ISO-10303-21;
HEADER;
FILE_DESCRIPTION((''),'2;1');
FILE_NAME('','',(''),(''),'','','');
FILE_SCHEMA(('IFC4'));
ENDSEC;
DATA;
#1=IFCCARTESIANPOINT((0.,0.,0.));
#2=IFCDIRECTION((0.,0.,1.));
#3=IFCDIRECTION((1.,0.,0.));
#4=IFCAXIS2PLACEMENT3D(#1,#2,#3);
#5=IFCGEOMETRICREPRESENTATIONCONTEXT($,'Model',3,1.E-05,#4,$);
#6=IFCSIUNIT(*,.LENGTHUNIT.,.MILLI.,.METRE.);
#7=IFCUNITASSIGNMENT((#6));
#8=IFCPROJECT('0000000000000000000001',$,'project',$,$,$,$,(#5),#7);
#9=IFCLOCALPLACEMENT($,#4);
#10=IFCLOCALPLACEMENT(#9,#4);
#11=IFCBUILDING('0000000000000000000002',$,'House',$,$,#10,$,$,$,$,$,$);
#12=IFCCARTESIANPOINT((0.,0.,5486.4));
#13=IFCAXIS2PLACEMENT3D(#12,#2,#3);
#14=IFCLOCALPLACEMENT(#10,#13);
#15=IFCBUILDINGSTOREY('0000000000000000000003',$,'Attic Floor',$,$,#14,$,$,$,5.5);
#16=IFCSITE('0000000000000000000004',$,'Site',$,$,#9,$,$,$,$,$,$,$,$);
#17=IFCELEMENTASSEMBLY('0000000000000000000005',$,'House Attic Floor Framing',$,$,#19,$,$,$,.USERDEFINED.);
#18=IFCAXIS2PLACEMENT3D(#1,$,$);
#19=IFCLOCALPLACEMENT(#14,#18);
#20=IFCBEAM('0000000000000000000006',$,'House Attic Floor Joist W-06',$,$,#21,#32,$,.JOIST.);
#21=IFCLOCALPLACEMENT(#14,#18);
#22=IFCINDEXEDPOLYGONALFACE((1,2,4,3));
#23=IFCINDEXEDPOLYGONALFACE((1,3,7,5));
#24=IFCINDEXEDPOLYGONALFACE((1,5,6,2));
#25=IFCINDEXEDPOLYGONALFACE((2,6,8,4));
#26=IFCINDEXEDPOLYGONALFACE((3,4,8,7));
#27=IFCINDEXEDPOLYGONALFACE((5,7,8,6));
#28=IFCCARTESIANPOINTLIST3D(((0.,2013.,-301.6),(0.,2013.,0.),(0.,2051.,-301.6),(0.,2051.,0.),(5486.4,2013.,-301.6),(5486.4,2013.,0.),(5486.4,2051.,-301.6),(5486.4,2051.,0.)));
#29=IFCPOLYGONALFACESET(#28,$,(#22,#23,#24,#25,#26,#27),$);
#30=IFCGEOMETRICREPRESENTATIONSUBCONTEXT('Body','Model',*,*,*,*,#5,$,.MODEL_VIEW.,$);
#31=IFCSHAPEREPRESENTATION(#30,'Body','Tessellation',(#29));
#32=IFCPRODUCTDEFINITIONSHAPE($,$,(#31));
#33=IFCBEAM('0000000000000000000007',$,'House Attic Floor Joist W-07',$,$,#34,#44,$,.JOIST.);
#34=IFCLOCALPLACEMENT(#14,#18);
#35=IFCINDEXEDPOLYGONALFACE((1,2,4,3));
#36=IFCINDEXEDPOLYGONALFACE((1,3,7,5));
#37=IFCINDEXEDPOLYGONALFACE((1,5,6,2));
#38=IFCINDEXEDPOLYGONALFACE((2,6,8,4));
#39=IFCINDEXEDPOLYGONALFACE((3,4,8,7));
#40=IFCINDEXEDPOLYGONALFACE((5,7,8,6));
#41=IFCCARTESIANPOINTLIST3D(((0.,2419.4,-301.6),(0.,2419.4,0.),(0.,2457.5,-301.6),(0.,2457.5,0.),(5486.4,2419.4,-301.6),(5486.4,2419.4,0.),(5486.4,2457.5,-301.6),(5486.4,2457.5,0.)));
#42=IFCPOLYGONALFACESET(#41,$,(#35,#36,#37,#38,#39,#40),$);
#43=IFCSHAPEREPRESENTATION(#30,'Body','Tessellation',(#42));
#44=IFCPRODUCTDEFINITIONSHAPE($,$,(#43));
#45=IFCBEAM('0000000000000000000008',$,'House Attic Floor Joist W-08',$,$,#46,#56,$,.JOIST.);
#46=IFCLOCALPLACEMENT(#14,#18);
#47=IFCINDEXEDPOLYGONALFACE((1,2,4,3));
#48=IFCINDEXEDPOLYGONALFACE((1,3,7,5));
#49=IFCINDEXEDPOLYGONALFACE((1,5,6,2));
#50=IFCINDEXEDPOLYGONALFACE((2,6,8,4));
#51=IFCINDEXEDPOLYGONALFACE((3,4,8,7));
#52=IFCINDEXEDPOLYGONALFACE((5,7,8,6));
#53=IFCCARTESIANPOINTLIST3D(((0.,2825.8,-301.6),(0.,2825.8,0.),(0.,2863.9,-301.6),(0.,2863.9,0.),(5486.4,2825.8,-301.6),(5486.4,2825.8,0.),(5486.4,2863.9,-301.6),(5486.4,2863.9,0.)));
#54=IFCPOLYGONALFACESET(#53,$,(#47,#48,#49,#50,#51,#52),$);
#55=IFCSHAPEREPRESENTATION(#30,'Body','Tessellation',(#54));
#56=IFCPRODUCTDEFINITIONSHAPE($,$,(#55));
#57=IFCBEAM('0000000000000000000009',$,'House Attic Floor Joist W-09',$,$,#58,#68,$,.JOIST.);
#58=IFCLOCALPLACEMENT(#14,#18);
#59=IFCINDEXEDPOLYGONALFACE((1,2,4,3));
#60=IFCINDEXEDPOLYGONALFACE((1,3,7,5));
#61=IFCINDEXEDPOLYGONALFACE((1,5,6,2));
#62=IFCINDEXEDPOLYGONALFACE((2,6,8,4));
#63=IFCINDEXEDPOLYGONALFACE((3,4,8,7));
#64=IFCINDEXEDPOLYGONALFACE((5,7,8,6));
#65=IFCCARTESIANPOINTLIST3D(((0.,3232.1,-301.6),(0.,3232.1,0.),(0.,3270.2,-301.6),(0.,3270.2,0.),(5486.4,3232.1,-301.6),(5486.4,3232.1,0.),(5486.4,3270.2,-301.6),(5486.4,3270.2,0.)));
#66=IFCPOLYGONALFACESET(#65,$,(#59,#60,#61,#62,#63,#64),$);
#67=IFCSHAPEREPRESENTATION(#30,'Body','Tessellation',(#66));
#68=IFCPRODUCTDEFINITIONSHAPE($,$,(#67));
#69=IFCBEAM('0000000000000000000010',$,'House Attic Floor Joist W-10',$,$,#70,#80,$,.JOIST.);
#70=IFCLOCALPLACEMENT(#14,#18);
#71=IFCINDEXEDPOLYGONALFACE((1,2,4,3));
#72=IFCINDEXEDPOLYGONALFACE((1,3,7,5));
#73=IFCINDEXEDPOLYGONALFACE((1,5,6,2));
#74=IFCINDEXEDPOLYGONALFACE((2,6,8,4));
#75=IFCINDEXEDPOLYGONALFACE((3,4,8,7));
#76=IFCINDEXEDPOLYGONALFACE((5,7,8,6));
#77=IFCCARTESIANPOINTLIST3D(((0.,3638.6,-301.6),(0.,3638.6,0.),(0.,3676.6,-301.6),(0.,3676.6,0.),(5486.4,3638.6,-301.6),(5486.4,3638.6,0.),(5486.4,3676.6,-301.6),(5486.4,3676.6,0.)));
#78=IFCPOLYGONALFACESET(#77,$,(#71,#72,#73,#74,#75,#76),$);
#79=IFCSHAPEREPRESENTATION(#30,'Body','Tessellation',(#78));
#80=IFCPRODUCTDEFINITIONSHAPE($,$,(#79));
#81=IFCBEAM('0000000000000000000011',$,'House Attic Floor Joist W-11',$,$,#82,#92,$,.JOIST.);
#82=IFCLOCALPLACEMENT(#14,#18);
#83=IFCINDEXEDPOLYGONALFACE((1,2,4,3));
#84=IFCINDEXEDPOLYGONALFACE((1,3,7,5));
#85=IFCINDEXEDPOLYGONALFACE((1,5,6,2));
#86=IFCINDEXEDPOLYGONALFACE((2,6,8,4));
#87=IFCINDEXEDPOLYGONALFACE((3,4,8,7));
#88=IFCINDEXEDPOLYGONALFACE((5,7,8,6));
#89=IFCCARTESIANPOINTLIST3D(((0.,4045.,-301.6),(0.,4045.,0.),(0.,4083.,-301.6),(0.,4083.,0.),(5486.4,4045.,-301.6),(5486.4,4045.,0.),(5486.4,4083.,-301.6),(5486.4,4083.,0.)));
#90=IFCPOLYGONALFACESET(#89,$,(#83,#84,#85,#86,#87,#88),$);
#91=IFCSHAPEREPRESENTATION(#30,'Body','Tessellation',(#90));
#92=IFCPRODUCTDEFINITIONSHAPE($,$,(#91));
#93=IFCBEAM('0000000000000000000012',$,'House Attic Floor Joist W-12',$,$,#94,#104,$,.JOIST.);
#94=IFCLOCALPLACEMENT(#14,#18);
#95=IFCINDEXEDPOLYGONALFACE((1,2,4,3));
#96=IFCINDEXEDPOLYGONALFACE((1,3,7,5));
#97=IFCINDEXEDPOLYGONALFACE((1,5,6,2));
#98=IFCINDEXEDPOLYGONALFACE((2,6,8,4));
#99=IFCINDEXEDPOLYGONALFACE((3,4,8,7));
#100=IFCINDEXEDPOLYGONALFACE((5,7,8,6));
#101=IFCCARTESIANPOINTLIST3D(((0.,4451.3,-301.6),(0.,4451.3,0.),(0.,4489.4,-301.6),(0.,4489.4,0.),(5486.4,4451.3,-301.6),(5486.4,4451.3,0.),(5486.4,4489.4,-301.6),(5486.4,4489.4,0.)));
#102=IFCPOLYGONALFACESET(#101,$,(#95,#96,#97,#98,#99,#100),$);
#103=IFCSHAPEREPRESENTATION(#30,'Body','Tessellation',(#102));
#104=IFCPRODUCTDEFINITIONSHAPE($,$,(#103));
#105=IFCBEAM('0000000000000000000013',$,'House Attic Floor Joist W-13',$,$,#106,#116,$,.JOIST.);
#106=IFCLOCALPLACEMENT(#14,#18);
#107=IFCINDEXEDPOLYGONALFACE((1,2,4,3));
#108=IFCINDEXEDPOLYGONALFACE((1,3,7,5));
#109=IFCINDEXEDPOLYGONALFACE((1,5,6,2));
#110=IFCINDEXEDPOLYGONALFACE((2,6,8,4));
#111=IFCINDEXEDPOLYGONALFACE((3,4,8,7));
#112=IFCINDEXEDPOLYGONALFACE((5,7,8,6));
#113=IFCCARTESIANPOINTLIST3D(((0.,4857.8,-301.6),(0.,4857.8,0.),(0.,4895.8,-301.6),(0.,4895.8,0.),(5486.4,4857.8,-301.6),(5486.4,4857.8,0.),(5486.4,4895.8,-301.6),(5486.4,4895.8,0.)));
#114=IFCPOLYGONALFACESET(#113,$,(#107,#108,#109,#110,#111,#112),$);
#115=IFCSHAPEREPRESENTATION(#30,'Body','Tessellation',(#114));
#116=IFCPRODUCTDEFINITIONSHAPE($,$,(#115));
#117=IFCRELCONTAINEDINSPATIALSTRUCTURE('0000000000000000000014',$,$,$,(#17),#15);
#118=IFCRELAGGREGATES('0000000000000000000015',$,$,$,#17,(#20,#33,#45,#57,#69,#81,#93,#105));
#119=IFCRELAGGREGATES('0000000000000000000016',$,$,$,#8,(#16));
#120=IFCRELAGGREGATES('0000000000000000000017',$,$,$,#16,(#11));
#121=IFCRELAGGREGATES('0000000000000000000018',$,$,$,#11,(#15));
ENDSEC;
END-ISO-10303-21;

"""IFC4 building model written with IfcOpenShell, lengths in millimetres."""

from ifc_helpers import new_model, si_unit, frame, origin_with_axes, origin_2d, place, context, subcontext, project, spatial, rectangle, extrude, element, aggregate, save


model = new_model("IFC4")

# Units and contexts
model_context = context("Model", 3, precision=1e-05, world=origin_with_axes())
body_context = subcontext(model_context, "Body", "Model", "MODEL_VIEW")
ifc_project = project(units=[si_unit("LENGTHUNIT", "METRE", prefix="MILLI")], contexts=[model_context])

# Site, building, storey
site_placement = place(None, origin_with_axes())
site = spatial("IfcSite", under=ifc_project, at=site_placement, Name="Site")
building_placement = place(site_placement, origin_with_axes())
building = spatial("IfcBuilding", under=site, at=building_placement, Name="House")
storey_placement = place(building_placement, frame((0.0, 0.0, 5486.4), z_axis=(0.0, 0.0, 1.0), x_axis=(1.0, 0.0, 0.0)))
storey = spatial("IfcBuildingStorey", under=building, at=storey_placement, Name="Attic Floor", Elevation=5.5)

# Element assembly, beams
assembly_1_placement = place(storey_placement, frame((0.0, 0.0, -5486.4), z_axis=(0.0, 0.0, 1.0), x_axis=(1.0, 0.0, 0.0)))
assembly_1 = element("IfcElementAssembly", 1, at=assembly_1_placement, inside=storey, Name="House Attic Floor Framing", PredefinedType="USERDEFINED")
beam_1_placement = place(assembly_1_placement, frame((0.0, 2032.0, 5335.6), z_axis=(1.0, 0.0, 0.0), x_axis=(0.0, 1.0, 0.0)))
beam_1 = element("IfcBeam", 2, at=beam_1_placement, Name="House Attic Floor Joist W-06", PredefinedType="JOIST", context=body_context, shape_type="SweptSolid", body=[
    extrude(rectangle(XDim=38.1, YDim=301.6, at=origin_2d()), origin_with_axes(), (0.0, 0.0, 1.0), 5486.4),
])
beam_2_placement = place(assembly_1_placement, frame((0.0, 2438.4, 5335.6), z_axis=(1.0, 0.0, 0.0), x_axis=(0.0, 1.0, 0.0)))
beam_2 = element("IfcBeam", 3, at=beam_2_placement, Name="House Attic Floor Joist W-07", PredefinedType="JOIST", context=body_context, shape_type="SweptSolid", body=[
    extrude(rectangle(XDim=38.1, YDim=301.6, at=origin_2d()), origin_with_axes(), (0.0, 0.0, 1.0), 5486.4),
])
beam_3_placement = place(assembly_1_placement, frame((0.0, 2844.8, 5335.6), z_axis=(1.0, 0.0, 0.0), x_axis=(0.0, 1.0, 0.0)))
beam_3 = element("IfcBeam", 4, at=beam_3_placement, Name="House Attic Floor Joist W-08", PredefinedType="JOIST", context=body_context, shape_type="SweptSolid", body=[
    extrude(rectangle(XDim=38.1, YDim=301.6, at=origin_2d()), origin_with_axes(), (0.0, 0.0, 1.0), 5486.4),
])
beam_4_placement = place(assembly_1_placement, frame((0.0, 3251.2, 5335.6), z_axis=(1.0, 0.0, 0.0), x_axis=(0.0, 1.0, 0.0)))
beam_4 = element("IfcBeam", 5, at=beam_4_placement, Name="House Attic Floor Joist W-09", PredefinedType="JOIST", context=body_context, shape_type="SweptSolid", body=[
    extrude(rectangle(XDim=38.1, YDim=301.6, at=origin_2d()), origin_with_axes(), (0.0, 0.0, 1.0), 5486.4),
])
beam_5_placement = place(assembly_1_placement, frame((0.0, 3657.6, 5335.6), z_axis=(1.0, 0.0, 0.0), x_axis=(0.0, 1.0, 0.0)))
beam_5 = element("IfcBeam", 6, at=beam_5_placement, Name="House Attic Floor Joist W-10", PredefinedType="JOIST", context=body_context, shape_type="SweptSolid", body=[
    extrude(rectangle(XDim=38.1, YDim=301.6, at=origin_2d()), origin_with_axes(), (0.0, 0.0, 1.0), 5486.4),
])
beam_6_placement = place(assembly_1_placement, frame((0.0, 4064.0, 5335.6), z_axis=(1.0, 0.0, 0.0), x_axis=(0.0, 1.0, 0.0)))
beam_6 = element("IfcBeam", 7, at=beam_6_placement, Name="House Attic Floor Joist W-11", PredefinedType="JOIST", context=body_context, shape_type="SweptSolid", body=[
    extrude(rectangle(XDim=38.1, YDim=301.6, at=origin_2d()), origin_with_axes(), (0.0, 0.0, 1.0), 5486.4),
])
beam_7_placement = place(assembly_1_placement, frame((0.0, 4470.4, 5335.6), z_axis=(1.0, 0.0, 0.0), x_axis=(0.0, 1.0, 0.0)))
beam_7 = element("IfcBeam", 8, at=beam_7_placement, Name="House Attic Floor Joist W-12", PredefinedType="JOIST", context=body_context, shape_type="SweptSolid", body=[
    extrude(rectangle(XDim=38.1, YDim=301.6, at=origin_2d()), origin_with_axes(), (0.0, 0.0, 1.0), 5486.4),
])
beam_8_placement = place(assembly_1_placement, frame((0.0, 4876.8, 5335.6), z_axis=(1.0, 0.0, 0.0), x_axis=(0.0, 1.0, 0.0)))
beam_8 = element("IfcBeam", 9, at=beam_8_placement, Name="House Attic Floor Joist W-13", PredefinedType="JOIST", context=body_context, shape_type="SweptSolid", body=[
    extrude(rectangle(XDim=38.1, YDim=301.6, at=origin_2d()), origin_with_axes(), (0.0, 0.0, 1.0), 5486.4),
])
aggregate(assembly_1, [beam_1, beam_2, beam_3, beam_4, beam_5, beam_6, beam_7, beam_8])

save(model, "model.ifc")
